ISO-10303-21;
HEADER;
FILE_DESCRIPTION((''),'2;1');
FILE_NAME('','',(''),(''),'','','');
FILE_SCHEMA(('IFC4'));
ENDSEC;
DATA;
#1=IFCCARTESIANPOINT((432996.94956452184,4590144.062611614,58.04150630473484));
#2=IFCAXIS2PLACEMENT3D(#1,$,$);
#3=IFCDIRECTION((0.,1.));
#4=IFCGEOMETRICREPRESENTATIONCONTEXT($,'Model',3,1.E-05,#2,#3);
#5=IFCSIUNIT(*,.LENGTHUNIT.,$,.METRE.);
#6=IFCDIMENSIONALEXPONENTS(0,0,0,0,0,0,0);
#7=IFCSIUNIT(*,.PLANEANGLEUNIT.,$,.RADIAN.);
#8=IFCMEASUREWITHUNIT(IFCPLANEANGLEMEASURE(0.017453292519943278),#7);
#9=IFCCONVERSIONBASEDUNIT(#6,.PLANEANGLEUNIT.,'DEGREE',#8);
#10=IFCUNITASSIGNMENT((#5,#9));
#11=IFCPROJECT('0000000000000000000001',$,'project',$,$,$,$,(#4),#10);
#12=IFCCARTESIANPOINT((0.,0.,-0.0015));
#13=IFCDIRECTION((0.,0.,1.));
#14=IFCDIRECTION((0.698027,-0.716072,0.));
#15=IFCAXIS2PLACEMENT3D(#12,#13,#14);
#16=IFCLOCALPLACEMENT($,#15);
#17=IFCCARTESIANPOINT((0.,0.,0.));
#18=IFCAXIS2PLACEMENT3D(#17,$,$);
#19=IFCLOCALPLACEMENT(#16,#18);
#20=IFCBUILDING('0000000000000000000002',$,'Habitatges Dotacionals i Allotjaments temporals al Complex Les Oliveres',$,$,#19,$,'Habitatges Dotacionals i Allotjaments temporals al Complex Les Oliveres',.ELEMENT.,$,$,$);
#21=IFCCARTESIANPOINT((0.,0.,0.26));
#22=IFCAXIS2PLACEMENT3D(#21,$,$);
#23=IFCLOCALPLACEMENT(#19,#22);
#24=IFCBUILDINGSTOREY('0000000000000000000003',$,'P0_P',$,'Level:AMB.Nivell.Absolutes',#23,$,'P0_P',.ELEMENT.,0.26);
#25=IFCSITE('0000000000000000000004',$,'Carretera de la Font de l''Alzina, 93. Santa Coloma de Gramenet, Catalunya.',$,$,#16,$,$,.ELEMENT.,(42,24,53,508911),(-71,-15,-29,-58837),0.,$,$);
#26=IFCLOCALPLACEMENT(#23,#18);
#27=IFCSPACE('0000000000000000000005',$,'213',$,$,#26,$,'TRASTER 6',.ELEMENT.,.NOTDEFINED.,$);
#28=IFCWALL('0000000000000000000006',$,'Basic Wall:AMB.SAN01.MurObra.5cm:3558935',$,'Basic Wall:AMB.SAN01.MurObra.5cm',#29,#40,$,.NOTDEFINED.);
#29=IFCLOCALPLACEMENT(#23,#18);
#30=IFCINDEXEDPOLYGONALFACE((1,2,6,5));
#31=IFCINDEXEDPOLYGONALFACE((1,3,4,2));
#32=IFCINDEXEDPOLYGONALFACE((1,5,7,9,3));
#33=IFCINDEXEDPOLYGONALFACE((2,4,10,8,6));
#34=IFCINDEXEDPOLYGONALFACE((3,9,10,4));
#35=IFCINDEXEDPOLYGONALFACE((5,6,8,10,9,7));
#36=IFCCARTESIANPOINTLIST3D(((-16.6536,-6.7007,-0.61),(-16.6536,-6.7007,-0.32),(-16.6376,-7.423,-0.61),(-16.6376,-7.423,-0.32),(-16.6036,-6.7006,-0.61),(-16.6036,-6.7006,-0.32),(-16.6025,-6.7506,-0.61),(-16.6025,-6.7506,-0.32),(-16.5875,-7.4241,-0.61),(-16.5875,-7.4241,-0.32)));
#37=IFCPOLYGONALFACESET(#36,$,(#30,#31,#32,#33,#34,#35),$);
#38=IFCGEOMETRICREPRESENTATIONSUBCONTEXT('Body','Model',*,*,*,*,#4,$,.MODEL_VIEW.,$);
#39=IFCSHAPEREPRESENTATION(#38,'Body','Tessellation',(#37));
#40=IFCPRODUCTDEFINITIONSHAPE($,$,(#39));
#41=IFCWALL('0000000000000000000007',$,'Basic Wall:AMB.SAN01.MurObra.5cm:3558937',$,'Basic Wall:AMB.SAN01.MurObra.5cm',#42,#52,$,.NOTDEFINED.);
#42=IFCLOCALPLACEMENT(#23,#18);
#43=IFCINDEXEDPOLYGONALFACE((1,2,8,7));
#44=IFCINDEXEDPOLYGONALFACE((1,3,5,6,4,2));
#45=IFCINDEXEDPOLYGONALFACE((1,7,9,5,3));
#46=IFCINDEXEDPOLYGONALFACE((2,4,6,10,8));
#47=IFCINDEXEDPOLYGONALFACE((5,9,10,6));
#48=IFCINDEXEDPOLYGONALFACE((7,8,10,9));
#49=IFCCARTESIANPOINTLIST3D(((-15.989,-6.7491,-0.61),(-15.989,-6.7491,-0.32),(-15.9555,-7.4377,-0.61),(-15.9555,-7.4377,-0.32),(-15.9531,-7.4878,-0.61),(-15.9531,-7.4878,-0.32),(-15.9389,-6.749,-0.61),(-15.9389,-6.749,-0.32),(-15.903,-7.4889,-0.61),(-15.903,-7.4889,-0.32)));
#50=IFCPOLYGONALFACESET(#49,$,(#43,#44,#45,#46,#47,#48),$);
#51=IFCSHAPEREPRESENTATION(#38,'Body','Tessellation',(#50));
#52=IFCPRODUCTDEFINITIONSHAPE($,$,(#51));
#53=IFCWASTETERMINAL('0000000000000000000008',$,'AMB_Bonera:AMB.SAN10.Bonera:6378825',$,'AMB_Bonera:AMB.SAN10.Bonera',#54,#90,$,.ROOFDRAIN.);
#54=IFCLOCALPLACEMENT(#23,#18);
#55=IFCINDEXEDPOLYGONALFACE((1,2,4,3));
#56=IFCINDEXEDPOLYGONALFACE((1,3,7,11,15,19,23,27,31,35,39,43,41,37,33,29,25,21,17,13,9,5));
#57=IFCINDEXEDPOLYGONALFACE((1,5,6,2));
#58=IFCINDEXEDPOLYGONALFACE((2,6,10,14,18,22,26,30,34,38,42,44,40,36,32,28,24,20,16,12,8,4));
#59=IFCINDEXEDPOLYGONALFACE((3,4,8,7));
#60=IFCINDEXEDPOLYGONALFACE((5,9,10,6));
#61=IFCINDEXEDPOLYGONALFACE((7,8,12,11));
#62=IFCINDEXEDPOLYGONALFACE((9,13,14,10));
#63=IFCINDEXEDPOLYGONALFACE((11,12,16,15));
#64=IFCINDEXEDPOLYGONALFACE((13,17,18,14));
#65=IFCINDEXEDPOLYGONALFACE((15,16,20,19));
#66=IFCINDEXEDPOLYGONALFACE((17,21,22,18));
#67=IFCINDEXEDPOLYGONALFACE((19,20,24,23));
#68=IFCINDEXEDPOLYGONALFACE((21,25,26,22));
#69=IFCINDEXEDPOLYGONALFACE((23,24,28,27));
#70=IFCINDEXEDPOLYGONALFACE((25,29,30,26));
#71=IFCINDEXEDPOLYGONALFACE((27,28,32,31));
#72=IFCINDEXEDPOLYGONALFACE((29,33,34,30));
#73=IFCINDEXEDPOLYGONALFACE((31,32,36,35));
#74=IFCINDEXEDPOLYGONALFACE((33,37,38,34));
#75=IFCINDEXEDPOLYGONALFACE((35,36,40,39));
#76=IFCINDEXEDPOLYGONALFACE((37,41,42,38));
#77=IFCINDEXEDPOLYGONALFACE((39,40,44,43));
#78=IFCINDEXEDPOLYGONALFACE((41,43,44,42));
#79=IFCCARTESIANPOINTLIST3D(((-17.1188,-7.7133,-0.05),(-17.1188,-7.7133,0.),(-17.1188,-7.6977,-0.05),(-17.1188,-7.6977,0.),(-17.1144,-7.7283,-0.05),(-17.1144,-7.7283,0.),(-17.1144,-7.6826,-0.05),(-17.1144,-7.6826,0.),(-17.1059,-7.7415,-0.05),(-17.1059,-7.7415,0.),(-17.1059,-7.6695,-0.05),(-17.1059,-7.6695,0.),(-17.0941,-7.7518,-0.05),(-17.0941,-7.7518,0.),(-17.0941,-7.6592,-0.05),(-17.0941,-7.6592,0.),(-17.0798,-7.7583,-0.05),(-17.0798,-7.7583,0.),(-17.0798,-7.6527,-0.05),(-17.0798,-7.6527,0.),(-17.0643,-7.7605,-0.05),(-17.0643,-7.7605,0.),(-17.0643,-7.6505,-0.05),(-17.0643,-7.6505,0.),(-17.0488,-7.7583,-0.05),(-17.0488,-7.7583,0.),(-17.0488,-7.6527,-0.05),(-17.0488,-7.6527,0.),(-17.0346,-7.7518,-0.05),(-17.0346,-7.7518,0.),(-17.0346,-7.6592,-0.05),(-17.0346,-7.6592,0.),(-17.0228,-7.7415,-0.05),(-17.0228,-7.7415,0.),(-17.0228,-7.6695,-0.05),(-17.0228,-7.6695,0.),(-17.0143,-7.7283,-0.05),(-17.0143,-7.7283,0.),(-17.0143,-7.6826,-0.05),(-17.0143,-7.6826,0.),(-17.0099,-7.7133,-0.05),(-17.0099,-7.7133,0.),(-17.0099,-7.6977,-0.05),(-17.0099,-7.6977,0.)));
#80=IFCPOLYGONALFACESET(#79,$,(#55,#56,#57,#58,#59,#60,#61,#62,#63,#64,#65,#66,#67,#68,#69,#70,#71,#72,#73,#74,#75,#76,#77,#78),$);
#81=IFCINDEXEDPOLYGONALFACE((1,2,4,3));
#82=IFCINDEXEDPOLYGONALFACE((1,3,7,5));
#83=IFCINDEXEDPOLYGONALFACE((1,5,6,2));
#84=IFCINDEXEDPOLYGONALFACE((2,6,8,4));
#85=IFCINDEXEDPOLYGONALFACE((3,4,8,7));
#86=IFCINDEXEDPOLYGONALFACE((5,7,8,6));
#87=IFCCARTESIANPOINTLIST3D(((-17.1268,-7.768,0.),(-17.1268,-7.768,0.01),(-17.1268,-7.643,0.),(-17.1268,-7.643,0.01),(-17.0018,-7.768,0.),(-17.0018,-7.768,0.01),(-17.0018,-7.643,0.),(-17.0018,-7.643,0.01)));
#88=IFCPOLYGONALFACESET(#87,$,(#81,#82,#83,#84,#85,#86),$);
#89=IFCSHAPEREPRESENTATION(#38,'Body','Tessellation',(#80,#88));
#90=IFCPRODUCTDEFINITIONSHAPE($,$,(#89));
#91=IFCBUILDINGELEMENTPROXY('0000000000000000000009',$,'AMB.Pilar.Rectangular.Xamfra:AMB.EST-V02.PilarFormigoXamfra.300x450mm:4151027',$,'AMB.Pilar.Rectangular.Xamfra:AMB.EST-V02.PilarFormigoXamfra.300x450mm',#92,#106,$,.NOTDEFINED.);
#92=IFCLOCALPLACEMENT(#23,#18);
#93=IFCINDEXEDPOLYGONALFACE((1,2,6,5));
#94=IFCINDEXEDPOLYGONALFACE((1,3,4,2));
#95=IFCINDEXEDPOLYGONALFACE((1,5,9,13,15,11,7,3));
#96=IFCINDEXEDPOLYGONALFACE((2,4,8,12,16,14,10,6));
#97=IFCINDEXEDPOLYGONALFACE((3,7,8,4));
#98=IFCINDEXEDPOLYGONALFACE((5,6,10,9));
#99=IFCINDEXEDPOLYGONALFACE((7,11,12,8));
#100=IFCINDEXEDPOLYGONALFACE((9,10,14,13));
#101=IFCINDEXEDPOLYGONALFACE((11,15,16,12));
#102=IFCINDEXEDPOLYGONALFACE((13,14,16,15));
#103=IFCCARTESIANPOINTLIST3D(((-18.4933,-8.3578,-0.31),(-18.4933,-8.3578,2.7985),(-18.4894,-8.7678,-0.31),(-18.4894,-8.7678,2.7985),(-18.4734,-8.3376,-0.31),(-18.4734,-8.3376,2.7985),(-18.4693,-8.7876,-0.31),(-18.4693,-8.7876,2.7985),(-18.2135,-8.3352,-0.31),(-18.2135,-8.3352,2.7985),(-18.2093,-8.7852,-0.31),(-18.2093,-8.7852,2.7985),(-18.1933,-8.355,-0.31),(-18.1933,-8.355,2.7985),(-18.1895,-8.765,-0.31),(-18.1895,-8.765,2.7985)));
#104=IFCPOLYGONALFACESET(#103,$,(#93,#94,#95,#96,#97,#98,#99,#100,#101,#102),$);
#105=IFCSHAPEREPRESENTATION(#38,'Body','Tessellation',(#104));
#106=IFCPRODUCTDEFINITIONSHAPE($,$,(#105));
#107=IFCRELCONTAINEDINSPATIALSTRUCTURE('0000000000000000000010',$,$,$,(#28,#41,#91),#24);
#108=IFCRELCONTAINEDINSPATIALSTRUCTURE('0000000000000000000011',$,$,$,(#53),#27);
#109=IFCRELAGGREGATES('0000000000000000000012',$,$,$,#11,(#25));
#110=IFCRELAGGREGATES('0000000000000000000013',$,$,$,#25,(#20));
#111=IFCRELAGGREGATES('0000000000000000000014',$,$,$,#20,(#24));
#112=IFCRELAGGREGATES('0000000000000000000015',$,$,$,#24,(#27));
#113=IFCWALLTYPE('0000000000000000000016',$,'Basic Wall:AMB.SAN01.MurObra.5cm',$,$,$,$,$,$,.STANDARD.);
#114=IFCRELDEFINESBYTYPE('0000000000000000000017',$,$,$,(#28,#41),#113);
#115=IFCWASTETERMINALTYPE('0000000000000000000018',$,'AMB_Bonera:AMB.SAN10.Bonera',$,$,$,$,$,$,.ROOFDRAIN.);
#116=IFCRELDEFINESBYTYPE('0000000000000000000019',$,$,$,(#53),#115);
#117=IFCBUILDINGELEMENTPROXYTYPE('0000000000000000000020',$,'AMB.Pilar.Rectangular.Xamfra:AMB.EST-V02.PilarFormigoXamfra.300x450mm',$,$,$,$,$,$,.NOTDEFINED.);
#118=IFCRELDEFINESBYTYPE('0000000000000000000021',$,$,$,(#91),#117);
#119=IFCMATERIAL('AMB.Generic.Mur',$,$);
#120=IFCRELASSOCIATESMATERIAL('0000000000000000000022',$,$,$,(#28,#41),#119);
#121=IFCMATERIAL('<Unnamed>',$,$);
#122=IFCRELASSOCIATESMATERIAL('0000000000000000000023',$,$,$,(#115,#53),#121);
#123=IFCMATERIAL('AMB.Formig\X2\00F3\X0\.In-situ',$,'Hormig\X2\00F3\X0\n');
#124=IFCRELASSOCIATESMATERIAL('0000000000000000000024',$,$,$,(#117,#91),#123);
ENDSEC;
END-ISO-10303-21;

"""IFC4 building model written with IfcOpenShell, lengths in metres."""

from ifc_helpers import new_model, entity, si_unit, converted_unit, direction, frame, origin, place, context, subcontext, project, spatial, arc, indexed_curve, outline, extrude, source, transform, mapped, material, type_object, type_shapes, element, save


model = new_model("IFC4")

# Units and contexts
model_context = context("Model", 3, precision=1e-05, world=frame((432996.94956452184, 4590144.062611614, 58.04150630473484)), true_north=direction((0.0, 1.0)))
body_context = subcontext(model_context, "Body", "Model", "MODEL_VIEW")
ifc_project = project(units=[si_unit("LENGTHUNIT", "METRE"), converted_unit("PLANEANGLEUNIT", "DEGREE", entity("IfcPlaneAngleMeasure", 0.017453292519943278), si_unit("PLANEANGLEUNIT", "RADIAN"), dimensions=[0, 0, 0, 0, 0, 0, 0])], contexts=[model_context])

# Site, building, storey
site_placement = place(None, frame((0.0, 0.0, -0.0015), z_axis=(0.0, 0.0, 1.0), x_axis=(0.698027, -0.716072, 0.0)))
site = spatial("IfcSite", under=ifc_project, at=site_placement, Name="Carretera de la Font de l'Alzina, 93. Santa Coloma de Gramenet, Catalunya.", CompositionType="ELEMENT", RefLatitude=(42, 24, 53, 508911), RefLongitude=(-71, -15, -29, -58837), RefElevation=0.0)
building_placement = place(site_placement, origin())
building = spatial("IfcBuilding", under=site, at=building_placement, Name="Habitatges Dotacionals i Allotjaments temporals al Complex Les Oliveres", LongName="Habitatges Dotacionals i Allotjaments temporals al Complex Les Oliveres", CompositionType="ELEMENT")
storey_placement = place(building_placement, frame((0.0, 0.0, 0.26)))
storey = spatial("IfcBuildingStorey", under=building, at=storey_placement, Name="P0_P", ObjectType="Level:AMB.Nivell.Absolutes", LongName="P0_P", CompositionType="ELEMENT", Elevation=0.26)

# Shared definitions
ifc_material_1 = material(Name="<Unnamed>")

# Walls
ifc_material_2 = material(Name="AMB.Generic.Mur")
wall_type = type_object("IfcWallType", Name="Basic Wall:AMB.SAN01.MurObra.5cm", PredefinedType="STANDARD")
wall_1_placement = place(storey_placement, frame((-16.6125, -7.4246, -0.61), z_axis=(0.0, 0.0, 1.0), x_axis=(-0.022199, 0.999754, 0.0)))
element("IfcWall", 1, at=wall_1_placement, inside=storey, type_object=wall_type, material=ifc_material_2, Name="Basic Wall:AMB.SAN01.MurObra.5cm:3558935", ObjectType="Basic Wall:AMB.SAN01.MurObra.5cm", PredefinedType="NOTDEFINED", context=body_context, shape_type="SweptSolid", body=[
    extrude(outline(indexed_curve([(0.7237, -0.025), (0.7247, 0.025), (0.0022, 0.025), (0.0, -0.025), (0.6737, -0.025), (0.7237, -0.025)], self_intersect=False)), origin(), (0.0, 0.0, 1.0), 0.29),
])
wall_2_placement = place(storey_placement, frame((-15.964, -6.7479, -0.61), z_axis=(0.0, 0.0, 1.0), x_axis=(0.048554, -0.998821, 0.0)))
element("IfcWall", 2, at=wall_2_placement, inside=storey, type_object=wall_type, material=ifc_material_2, Name="Basic Wall:AMB.SAN01.MurObra.5cm:3558937", ObjectType="Basic Wall:AMB.SAN01.MurObra.5cm", PredefinedType="NOTDEFINED", context=body_context, shape_type="SweptSolid", body=[
    extrude(outline(indexed_curve([(0.7395, -0.025), (0.7431, 0.025), (0.0023, 0.025), (0.0, -0.025), (0.6894, -0.025), (0.7395, -0.025)], self_intersect=False)), origin(), (0.0, 0.0, 1.0), 0.29),
])

# Shared definitions
space_placement = place(storey_placement, origin())
space = spatial("IfcSpace", under=storey, at=space_placement, Name="213", LongName="TRASTER 6", CompositionType="ELEMENT", PredefinedType="NOTDEFINED")

# Waste terminal
waste_terminal_type = type_object("IfcWasteTerminalType", Name="AMB_Bonera:AMB.SAN10.Bonera", PredefinedType="ROOFDRAIN", material=ifc_material_1)
shared_shape_1 = source(origin(), body_context, "Body", "SweptSolid", [
    extrude(outline(indexed_curve([(-0.055, 0.0), (0.0, -0.055), (0.055, 0.0), (0.0, 0.055)], segments=[arc(1, 2, 3), arc(3, 4, 1)], self_intersect=False)), frame((0.0, 0.0, -0.05), z_axis=(0.0, 0.0, 1.0), x_axis=(0.0, -1.0, 0.0)), (0.0, 0.0, 1.0), 0.05),
    extrude(outline(indexed_curve([(-0.0625, -0.0625), (0.0625, -0.0625), (0.0625, 0.0625), (-0.0625, 0.0625), (-0.0625, -0.0625)], self_intersect=False)), frame((0.0, 0.0, 0.0), z_axis=(0.0, 0.0, 1.0), x_axis=(-1.0, 0.0, 0.0)), (0.0, 0.0, 1.0), 0.01),
])
type_shapes(waste_terminal_type, [shared_shape_1])
waste_terminal_placement = place(space_placement, frame((-17.0643, -7.7055, 0.0)))
element("IfcWasteTerminal", 3, at=waste_terminal_placement, inside=space, type_object=waste_terminal_type, material=ifc_material_1, Name="AMB_Bonera:AMB.SAN10.Bonera:6378825", ObjectType="AMB_Bonera:AMB.SAN10.Bonera", PredefinedType="ROOFDRAIN", context=body_context, shape_type="MappedRepresentation", body=[
    mapped(shared_shape_1, transform((0.0, 0.0, 0.0), scale=1.0)),
])

# Building element proxy
ifc_material_3 = material(Name="AMB.Formigó.In-situ", Category="Hormigón")
building_element_proxy_type = type_object("IfcBuildingElementProxyType", Name="AMB.Pilar.Rectangular.Xamfra:AMB.EST-V02.PilarFormigoXamfra.300x450mm", PredefinedType="NOTDEFINED", material=ifc_material_3)
shared_shape_2 = source(origin(), body_context, "Body", "SweptSolid", [
    extrude(outline(indexed_curve([(-0.13, -0.225), (0.13, -0.225), (0.15, -0.205), (0.15, 0.205), (0.13, 0.225), (-0.13, 0.225), (-0.15, 0.205), (-0.15, -0.205), (-0.13, -0.225)], self_intersect=False)), frame((0.0, 0.0, -0.05), z_axis=(0.0, 0.0, 1.0), x_axis=(-1.0, 0.0, 0.0)), (0.0, 0.0, 1.0), 3.1085),
])
type_shapes(building_element_proxy_type, [shared_shape_2])
proxy_placement = place(storey_placement, frame((-18.3414, -8.5614, -0.26), z_axis=(0.0, 0.0, 1.0), x_axis=(0.999957, 0.009302, 0.0)))
element("IfcBuildingElementProxy", 4, at=proxy_placement, inside=storey, type_object=building_element_proxy_type, material=ifc_material_3, Name="AMB.Pilar.Rectangular.Xamfra:AMB.EST-V02.PilarFormigoXamfra.300x450mm:4151027", ObjectType="AMB.Pilar.Rectangular.Xamfra:AMB.EST-V02.PilarFormigoXamfra.300x450mm", PredefinedType="NOTDEFINED", context=body_context, shape_type="MappedRepresentation", body=[
    mapped(shared_shape_2, transform((0.0, 0.0, 0.0), scale=1.0)),
])

save(model, "model.ifc")
